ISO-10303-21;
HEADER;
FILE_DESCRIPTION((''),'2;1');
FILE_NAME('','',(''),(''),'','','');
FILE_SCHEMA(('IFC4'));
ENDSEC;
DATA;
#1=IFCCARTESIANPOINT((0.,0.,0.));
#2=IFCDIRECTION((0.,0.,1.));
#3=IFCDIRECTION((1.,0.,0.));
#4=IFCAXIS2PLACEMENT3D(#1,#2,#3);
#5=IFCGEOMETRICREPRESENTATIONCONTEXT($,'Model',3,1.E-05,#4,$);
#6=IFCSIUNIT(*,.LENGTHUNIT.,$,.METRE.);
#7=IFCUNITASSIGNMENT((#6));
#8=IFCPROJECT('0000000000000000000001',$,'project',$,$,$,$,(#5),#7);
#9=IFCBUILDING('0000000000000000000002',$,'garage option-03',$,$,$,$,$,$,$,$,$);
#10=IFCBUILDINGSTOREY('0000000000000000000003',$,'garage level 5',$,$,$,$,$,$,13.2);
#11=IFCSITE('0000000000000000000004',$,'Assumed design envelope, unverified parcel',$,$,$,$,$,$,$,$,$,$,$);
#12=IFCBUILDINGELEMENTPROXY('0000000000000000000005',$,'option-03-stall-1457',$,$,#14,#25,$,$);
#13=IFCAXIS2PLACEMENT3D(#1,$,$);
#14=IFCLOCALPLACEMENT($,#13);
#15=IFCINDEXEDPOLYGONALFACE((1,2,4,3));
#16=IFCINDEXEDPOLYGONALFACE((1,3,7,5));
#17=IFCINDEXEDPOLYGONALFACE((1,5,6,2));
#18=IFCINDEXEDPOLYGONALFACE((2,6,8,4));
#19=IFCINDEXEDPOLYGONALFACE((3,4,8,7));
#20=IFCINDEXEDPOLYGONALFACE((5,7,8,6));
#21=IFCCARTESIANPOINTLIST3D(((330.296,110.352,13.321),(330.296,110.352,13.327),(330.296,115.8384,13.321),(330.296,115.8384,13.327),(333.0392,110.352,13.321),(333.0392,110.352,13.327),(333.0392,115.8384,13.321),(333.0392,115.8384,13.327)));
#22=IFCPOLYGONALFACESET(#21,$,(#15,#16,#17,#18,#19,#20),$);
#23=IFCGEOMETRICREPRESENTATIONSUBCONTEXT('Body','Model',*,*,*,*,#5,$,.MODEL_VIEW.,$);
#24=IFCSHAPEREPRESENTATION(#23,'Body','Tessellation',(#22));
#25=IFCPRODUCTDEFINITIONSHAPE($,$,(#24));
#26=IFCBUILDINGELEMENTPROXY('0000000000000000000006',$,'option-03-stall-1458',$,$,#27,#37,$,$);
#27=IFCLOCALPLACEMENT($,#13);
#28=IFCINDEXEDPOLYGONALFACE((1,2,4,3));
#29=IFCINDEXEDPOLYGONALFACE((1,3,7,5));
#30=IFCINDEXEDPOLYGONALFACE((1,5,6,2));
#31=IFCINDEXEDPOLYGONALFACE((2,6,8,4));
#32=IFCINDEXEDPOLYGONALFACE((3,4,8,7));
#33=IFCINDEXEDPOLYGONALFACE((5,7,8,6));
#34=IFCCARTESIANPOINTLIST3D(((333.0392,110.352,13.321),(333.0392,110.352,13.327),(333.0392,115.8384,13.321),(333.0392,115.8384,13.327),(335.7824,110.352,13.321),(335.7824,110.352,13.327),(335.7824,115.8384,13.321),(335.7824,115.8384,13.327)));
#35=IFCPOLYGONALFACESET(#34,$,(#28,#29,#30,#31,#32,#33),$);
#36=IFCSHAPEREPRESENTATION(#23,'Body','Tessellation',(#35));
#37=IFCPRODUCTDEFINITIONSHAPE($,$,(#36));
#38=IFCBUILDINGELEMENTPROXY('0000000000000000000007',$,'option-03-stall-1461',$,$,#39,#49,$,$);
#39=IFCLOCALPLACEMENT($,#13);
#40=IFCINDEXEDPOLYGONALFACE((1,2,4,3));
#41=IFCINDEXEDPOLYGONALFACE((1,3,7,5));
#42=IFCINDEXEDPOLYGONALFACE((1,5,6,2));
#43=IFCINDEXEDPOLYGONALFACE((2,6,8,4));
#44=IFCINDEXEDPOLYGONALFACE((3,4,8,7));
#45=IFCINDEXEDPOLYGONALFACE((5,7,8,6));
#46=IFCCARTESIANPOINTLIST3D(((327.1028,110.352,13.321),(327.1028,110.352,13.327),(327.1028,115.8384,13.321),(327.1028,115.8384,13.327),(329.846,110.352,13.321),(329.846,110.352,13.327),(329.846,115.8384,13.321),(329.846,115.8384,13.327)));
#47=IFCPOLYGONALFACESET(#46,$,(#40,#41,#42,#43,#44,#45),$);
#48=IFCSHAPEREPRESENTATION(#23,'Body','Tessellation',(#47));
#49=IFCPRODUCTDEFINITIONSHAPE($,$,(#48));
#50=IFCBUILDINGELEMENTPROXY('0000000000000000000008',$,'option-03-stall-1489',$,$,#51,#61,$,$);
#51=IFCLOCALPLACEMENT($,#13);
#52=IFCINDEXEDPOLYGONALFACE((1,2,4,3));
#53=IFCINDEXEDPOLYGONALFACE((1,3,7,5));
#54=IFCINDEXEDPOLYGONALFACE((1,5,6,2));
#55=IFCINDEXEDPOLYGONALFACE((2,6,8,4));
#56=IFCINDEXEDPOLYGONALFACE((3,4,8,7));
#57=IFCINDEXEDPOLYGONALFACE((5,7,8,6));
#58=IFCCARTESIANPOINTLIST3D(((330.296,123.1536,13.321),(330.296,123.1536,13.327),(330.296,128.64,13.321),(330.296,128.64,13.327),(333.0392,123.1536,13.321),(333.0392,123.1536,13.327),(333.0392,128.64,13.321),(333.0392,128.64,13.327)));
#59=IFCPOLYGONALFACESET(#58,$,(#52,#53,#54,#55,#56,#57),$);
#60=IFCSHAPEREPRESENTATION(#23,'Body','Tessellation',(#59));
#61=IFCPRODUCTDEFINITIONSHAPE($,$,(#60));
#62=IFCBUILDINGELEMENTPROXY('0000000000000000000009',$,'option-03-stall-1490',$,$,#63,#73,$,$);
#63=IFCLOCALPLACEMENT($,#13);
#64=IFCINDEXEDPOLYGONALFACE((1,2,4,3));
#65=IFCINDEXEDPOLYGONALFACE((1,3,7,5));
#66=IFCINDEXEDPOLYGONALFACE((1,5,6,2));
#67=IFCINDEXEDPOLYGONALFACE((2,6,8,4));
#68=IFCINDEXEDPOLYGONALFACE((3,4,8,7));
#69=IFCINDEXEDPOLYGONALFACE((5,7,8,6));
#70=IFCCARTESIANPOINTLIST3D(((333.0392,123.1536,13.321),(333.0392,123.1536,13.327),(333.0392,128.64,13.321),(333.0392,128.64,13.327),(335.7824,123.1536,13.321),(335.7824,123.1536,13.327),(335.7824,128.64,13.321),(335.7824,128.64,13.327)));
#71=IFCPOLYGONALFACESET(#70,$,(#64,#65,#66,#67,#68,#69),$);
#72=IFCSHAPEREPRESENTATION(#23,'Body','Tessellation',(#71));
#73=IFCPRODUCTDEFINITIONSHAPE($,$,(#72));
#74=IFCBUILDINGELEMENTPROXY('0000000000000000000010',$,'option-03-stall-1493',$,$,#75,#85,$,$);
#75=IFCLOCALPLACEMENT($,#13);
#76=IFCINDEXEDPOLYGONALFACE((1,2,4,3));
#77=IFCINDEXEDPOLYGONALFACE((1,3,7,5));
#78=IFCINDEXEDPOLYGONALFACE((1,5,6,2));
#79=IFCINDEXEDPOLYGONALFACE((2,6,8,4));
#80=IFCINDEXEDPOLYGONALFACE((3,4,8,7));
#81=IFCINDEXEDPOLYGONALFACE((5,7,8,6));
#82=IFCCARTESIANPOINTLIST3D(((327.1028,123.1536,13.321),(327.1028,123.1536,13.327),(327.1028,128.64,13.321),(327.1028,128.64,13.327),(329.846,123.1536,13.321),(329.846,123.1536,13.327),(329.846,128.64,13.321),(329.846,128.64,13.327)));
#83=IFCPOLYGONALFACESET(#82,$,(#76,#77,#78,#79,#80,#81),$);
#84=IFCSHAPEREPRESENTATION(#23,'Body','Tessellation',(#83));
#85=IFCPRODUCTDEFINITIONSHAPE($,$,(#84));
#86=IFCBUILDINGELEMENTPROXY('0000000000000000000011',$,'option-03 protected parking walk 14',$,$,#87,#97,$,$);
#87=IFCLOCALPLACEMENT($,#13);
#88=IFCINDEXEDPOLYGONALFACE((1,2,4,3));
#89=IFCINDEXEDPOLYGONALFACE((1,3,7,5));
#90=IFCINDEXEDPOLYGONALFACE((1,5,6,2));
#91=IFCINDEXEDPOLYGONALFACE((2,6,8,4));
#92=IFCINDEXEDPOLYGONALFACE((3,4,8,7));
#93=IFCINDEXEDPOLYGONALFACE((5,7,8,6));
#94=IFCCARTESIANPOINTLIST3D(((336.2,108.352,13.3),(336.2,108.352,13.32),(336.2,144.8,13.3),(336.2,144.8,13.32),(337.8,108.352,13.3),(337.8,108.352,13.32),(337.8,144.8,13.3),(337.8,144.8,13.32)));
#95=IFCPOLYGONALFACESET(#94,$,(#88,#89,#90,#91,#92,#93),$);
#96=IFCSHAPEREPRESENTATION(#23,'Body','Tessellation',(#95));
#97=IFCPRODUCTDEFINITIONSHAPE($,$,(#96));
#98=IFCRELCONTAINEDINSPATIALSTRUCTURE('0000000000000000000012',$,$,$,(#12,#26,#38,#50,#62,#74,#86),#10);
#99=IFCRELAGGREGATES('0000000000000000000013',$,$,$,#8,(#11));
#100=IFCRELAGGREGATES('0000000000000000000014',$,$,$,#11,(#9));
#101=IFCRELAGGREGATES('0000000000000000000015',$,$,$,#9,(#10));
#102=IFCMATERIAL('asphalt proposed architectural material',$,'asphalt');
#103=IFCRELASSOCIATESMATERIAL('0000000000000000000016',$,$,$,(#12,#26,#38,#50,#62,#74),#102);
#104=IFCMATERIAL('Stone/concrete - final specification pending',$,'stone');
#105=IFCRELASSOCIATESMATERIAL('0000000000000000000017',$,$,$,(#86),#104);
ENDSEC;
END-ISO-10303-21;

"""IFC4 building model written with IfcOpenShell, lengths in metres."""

from ifc_helpers import new_model, si_unit, frame, origin_with_axes, place, context, subcontext, project, spatial, rectangle, extrude, material, element, save


model = new_model("IFC4")

# Units and contexts
model_context = context("Model", 3, precision=1e-05, world=origin_with_axes())
body_context = subcontext(model_context, "Body", "Model", "MODEL_VIEW")
ifc_project = project(units=[si_unit("LENGTHUNIT", "METRE")], contexts=[model_context])

# Site, building, storey
site = spatial("IfcSite", under=ifc_project, Name="Assumed design envelope, unverified parcel")
building = spatial("IfcBuilding", under=site, Name="garage option-03")
storey = spatial("IfcBuildingStorey", under=building, Name="garage level 5", Elevation=13.2)

# Building element proxies
ifc_material_1 = material(Name="asphalt proposed architectural material", Category="asphalt")
for number, where, z_axis, x_axis, name in (
    (1, (331.6676, 113.0952, 13.321), (0.0, 0.0, 1.0), (1.0, 0.0, 0.0), "option-03-stall-1457"),
    (2, (334.4108, 113.0952, 13.321), (0.0, 0.0, 1.0), (1.0, 0.0, 0.0), "option-03-stall-1458"),
    (3, (328.4744, 113.0952, 13.321), (0.0, 0.0, 1.0), (1.0, 0.0, 0.0), "option-03-stall-1461"),
):
    element("IfcBuildingElementProxy", number, at=place(None, frame(where, z_axis=z_axis, x_axis=x_axis)), inside=storey, material=ifc_material_1, Name=name, context=body_context, shape_type="SweptSolid", body=[
        extrude(rectangle(XDim=2.7432, YDim=5.4864), origin_with_axes(), (0.0, 0.0, 1.0), 0.006),
    ])
for number, where, z_axis, x_axis, name in (
    (4, (331.6676, 125.8968, 13.321), (0.0, 0.0, 1.0), (1.0, 0.0, 0.0), "option-03-stall-1489"),
    (5, (334.4108, 125.8968, 13.321), (0.0, 0.0, 1.0), (1.0, 0.0, 0.0), "option-03-stall-1490"),
    (6, (328.4744, 125.8968, 13.321), (0.0, 0.0, 1.0), (1.0, 0.0, 0.0), "option-03-stall-1493"),
):
    element("IfcBuildingElementProxy", number, at=place(None, frame(where, z_axis=z_axis, x_axis=x_axis)), inside=storey, material=ifc_material_1, Name=name, context=body_context, shape_type="SweptSolid", body=[
        extrude(rectangle(XDim=2.7432, YDim=5.4864), origin_with_axes(), (0.0, 0.0, 1.0), 0.006),
    ])
ifc_material_2 = material(Name="Stone/concrete - final specification pending", Category="stone")
proxy_placement = place(None, frame((337.0, 126.576, 13.3), z_axis=(0.0, 0.0, 1.0), x_axis=(1.0, 0.0, 0.0)))
element("IfcBuildingElementProxy", 7, at=proxy_placement, inside=storey, material=ifc_material_2, Name="option-03 protected parking walk 14", context=body_context, shape_type="SweptSolid", body=[
    extrude(rectangle(XDim=1.6, YDim=36.448), origin_with_axes(), (0.0, 0.0, 1.0), 0.02),
])

save(model, "model.ifc")
